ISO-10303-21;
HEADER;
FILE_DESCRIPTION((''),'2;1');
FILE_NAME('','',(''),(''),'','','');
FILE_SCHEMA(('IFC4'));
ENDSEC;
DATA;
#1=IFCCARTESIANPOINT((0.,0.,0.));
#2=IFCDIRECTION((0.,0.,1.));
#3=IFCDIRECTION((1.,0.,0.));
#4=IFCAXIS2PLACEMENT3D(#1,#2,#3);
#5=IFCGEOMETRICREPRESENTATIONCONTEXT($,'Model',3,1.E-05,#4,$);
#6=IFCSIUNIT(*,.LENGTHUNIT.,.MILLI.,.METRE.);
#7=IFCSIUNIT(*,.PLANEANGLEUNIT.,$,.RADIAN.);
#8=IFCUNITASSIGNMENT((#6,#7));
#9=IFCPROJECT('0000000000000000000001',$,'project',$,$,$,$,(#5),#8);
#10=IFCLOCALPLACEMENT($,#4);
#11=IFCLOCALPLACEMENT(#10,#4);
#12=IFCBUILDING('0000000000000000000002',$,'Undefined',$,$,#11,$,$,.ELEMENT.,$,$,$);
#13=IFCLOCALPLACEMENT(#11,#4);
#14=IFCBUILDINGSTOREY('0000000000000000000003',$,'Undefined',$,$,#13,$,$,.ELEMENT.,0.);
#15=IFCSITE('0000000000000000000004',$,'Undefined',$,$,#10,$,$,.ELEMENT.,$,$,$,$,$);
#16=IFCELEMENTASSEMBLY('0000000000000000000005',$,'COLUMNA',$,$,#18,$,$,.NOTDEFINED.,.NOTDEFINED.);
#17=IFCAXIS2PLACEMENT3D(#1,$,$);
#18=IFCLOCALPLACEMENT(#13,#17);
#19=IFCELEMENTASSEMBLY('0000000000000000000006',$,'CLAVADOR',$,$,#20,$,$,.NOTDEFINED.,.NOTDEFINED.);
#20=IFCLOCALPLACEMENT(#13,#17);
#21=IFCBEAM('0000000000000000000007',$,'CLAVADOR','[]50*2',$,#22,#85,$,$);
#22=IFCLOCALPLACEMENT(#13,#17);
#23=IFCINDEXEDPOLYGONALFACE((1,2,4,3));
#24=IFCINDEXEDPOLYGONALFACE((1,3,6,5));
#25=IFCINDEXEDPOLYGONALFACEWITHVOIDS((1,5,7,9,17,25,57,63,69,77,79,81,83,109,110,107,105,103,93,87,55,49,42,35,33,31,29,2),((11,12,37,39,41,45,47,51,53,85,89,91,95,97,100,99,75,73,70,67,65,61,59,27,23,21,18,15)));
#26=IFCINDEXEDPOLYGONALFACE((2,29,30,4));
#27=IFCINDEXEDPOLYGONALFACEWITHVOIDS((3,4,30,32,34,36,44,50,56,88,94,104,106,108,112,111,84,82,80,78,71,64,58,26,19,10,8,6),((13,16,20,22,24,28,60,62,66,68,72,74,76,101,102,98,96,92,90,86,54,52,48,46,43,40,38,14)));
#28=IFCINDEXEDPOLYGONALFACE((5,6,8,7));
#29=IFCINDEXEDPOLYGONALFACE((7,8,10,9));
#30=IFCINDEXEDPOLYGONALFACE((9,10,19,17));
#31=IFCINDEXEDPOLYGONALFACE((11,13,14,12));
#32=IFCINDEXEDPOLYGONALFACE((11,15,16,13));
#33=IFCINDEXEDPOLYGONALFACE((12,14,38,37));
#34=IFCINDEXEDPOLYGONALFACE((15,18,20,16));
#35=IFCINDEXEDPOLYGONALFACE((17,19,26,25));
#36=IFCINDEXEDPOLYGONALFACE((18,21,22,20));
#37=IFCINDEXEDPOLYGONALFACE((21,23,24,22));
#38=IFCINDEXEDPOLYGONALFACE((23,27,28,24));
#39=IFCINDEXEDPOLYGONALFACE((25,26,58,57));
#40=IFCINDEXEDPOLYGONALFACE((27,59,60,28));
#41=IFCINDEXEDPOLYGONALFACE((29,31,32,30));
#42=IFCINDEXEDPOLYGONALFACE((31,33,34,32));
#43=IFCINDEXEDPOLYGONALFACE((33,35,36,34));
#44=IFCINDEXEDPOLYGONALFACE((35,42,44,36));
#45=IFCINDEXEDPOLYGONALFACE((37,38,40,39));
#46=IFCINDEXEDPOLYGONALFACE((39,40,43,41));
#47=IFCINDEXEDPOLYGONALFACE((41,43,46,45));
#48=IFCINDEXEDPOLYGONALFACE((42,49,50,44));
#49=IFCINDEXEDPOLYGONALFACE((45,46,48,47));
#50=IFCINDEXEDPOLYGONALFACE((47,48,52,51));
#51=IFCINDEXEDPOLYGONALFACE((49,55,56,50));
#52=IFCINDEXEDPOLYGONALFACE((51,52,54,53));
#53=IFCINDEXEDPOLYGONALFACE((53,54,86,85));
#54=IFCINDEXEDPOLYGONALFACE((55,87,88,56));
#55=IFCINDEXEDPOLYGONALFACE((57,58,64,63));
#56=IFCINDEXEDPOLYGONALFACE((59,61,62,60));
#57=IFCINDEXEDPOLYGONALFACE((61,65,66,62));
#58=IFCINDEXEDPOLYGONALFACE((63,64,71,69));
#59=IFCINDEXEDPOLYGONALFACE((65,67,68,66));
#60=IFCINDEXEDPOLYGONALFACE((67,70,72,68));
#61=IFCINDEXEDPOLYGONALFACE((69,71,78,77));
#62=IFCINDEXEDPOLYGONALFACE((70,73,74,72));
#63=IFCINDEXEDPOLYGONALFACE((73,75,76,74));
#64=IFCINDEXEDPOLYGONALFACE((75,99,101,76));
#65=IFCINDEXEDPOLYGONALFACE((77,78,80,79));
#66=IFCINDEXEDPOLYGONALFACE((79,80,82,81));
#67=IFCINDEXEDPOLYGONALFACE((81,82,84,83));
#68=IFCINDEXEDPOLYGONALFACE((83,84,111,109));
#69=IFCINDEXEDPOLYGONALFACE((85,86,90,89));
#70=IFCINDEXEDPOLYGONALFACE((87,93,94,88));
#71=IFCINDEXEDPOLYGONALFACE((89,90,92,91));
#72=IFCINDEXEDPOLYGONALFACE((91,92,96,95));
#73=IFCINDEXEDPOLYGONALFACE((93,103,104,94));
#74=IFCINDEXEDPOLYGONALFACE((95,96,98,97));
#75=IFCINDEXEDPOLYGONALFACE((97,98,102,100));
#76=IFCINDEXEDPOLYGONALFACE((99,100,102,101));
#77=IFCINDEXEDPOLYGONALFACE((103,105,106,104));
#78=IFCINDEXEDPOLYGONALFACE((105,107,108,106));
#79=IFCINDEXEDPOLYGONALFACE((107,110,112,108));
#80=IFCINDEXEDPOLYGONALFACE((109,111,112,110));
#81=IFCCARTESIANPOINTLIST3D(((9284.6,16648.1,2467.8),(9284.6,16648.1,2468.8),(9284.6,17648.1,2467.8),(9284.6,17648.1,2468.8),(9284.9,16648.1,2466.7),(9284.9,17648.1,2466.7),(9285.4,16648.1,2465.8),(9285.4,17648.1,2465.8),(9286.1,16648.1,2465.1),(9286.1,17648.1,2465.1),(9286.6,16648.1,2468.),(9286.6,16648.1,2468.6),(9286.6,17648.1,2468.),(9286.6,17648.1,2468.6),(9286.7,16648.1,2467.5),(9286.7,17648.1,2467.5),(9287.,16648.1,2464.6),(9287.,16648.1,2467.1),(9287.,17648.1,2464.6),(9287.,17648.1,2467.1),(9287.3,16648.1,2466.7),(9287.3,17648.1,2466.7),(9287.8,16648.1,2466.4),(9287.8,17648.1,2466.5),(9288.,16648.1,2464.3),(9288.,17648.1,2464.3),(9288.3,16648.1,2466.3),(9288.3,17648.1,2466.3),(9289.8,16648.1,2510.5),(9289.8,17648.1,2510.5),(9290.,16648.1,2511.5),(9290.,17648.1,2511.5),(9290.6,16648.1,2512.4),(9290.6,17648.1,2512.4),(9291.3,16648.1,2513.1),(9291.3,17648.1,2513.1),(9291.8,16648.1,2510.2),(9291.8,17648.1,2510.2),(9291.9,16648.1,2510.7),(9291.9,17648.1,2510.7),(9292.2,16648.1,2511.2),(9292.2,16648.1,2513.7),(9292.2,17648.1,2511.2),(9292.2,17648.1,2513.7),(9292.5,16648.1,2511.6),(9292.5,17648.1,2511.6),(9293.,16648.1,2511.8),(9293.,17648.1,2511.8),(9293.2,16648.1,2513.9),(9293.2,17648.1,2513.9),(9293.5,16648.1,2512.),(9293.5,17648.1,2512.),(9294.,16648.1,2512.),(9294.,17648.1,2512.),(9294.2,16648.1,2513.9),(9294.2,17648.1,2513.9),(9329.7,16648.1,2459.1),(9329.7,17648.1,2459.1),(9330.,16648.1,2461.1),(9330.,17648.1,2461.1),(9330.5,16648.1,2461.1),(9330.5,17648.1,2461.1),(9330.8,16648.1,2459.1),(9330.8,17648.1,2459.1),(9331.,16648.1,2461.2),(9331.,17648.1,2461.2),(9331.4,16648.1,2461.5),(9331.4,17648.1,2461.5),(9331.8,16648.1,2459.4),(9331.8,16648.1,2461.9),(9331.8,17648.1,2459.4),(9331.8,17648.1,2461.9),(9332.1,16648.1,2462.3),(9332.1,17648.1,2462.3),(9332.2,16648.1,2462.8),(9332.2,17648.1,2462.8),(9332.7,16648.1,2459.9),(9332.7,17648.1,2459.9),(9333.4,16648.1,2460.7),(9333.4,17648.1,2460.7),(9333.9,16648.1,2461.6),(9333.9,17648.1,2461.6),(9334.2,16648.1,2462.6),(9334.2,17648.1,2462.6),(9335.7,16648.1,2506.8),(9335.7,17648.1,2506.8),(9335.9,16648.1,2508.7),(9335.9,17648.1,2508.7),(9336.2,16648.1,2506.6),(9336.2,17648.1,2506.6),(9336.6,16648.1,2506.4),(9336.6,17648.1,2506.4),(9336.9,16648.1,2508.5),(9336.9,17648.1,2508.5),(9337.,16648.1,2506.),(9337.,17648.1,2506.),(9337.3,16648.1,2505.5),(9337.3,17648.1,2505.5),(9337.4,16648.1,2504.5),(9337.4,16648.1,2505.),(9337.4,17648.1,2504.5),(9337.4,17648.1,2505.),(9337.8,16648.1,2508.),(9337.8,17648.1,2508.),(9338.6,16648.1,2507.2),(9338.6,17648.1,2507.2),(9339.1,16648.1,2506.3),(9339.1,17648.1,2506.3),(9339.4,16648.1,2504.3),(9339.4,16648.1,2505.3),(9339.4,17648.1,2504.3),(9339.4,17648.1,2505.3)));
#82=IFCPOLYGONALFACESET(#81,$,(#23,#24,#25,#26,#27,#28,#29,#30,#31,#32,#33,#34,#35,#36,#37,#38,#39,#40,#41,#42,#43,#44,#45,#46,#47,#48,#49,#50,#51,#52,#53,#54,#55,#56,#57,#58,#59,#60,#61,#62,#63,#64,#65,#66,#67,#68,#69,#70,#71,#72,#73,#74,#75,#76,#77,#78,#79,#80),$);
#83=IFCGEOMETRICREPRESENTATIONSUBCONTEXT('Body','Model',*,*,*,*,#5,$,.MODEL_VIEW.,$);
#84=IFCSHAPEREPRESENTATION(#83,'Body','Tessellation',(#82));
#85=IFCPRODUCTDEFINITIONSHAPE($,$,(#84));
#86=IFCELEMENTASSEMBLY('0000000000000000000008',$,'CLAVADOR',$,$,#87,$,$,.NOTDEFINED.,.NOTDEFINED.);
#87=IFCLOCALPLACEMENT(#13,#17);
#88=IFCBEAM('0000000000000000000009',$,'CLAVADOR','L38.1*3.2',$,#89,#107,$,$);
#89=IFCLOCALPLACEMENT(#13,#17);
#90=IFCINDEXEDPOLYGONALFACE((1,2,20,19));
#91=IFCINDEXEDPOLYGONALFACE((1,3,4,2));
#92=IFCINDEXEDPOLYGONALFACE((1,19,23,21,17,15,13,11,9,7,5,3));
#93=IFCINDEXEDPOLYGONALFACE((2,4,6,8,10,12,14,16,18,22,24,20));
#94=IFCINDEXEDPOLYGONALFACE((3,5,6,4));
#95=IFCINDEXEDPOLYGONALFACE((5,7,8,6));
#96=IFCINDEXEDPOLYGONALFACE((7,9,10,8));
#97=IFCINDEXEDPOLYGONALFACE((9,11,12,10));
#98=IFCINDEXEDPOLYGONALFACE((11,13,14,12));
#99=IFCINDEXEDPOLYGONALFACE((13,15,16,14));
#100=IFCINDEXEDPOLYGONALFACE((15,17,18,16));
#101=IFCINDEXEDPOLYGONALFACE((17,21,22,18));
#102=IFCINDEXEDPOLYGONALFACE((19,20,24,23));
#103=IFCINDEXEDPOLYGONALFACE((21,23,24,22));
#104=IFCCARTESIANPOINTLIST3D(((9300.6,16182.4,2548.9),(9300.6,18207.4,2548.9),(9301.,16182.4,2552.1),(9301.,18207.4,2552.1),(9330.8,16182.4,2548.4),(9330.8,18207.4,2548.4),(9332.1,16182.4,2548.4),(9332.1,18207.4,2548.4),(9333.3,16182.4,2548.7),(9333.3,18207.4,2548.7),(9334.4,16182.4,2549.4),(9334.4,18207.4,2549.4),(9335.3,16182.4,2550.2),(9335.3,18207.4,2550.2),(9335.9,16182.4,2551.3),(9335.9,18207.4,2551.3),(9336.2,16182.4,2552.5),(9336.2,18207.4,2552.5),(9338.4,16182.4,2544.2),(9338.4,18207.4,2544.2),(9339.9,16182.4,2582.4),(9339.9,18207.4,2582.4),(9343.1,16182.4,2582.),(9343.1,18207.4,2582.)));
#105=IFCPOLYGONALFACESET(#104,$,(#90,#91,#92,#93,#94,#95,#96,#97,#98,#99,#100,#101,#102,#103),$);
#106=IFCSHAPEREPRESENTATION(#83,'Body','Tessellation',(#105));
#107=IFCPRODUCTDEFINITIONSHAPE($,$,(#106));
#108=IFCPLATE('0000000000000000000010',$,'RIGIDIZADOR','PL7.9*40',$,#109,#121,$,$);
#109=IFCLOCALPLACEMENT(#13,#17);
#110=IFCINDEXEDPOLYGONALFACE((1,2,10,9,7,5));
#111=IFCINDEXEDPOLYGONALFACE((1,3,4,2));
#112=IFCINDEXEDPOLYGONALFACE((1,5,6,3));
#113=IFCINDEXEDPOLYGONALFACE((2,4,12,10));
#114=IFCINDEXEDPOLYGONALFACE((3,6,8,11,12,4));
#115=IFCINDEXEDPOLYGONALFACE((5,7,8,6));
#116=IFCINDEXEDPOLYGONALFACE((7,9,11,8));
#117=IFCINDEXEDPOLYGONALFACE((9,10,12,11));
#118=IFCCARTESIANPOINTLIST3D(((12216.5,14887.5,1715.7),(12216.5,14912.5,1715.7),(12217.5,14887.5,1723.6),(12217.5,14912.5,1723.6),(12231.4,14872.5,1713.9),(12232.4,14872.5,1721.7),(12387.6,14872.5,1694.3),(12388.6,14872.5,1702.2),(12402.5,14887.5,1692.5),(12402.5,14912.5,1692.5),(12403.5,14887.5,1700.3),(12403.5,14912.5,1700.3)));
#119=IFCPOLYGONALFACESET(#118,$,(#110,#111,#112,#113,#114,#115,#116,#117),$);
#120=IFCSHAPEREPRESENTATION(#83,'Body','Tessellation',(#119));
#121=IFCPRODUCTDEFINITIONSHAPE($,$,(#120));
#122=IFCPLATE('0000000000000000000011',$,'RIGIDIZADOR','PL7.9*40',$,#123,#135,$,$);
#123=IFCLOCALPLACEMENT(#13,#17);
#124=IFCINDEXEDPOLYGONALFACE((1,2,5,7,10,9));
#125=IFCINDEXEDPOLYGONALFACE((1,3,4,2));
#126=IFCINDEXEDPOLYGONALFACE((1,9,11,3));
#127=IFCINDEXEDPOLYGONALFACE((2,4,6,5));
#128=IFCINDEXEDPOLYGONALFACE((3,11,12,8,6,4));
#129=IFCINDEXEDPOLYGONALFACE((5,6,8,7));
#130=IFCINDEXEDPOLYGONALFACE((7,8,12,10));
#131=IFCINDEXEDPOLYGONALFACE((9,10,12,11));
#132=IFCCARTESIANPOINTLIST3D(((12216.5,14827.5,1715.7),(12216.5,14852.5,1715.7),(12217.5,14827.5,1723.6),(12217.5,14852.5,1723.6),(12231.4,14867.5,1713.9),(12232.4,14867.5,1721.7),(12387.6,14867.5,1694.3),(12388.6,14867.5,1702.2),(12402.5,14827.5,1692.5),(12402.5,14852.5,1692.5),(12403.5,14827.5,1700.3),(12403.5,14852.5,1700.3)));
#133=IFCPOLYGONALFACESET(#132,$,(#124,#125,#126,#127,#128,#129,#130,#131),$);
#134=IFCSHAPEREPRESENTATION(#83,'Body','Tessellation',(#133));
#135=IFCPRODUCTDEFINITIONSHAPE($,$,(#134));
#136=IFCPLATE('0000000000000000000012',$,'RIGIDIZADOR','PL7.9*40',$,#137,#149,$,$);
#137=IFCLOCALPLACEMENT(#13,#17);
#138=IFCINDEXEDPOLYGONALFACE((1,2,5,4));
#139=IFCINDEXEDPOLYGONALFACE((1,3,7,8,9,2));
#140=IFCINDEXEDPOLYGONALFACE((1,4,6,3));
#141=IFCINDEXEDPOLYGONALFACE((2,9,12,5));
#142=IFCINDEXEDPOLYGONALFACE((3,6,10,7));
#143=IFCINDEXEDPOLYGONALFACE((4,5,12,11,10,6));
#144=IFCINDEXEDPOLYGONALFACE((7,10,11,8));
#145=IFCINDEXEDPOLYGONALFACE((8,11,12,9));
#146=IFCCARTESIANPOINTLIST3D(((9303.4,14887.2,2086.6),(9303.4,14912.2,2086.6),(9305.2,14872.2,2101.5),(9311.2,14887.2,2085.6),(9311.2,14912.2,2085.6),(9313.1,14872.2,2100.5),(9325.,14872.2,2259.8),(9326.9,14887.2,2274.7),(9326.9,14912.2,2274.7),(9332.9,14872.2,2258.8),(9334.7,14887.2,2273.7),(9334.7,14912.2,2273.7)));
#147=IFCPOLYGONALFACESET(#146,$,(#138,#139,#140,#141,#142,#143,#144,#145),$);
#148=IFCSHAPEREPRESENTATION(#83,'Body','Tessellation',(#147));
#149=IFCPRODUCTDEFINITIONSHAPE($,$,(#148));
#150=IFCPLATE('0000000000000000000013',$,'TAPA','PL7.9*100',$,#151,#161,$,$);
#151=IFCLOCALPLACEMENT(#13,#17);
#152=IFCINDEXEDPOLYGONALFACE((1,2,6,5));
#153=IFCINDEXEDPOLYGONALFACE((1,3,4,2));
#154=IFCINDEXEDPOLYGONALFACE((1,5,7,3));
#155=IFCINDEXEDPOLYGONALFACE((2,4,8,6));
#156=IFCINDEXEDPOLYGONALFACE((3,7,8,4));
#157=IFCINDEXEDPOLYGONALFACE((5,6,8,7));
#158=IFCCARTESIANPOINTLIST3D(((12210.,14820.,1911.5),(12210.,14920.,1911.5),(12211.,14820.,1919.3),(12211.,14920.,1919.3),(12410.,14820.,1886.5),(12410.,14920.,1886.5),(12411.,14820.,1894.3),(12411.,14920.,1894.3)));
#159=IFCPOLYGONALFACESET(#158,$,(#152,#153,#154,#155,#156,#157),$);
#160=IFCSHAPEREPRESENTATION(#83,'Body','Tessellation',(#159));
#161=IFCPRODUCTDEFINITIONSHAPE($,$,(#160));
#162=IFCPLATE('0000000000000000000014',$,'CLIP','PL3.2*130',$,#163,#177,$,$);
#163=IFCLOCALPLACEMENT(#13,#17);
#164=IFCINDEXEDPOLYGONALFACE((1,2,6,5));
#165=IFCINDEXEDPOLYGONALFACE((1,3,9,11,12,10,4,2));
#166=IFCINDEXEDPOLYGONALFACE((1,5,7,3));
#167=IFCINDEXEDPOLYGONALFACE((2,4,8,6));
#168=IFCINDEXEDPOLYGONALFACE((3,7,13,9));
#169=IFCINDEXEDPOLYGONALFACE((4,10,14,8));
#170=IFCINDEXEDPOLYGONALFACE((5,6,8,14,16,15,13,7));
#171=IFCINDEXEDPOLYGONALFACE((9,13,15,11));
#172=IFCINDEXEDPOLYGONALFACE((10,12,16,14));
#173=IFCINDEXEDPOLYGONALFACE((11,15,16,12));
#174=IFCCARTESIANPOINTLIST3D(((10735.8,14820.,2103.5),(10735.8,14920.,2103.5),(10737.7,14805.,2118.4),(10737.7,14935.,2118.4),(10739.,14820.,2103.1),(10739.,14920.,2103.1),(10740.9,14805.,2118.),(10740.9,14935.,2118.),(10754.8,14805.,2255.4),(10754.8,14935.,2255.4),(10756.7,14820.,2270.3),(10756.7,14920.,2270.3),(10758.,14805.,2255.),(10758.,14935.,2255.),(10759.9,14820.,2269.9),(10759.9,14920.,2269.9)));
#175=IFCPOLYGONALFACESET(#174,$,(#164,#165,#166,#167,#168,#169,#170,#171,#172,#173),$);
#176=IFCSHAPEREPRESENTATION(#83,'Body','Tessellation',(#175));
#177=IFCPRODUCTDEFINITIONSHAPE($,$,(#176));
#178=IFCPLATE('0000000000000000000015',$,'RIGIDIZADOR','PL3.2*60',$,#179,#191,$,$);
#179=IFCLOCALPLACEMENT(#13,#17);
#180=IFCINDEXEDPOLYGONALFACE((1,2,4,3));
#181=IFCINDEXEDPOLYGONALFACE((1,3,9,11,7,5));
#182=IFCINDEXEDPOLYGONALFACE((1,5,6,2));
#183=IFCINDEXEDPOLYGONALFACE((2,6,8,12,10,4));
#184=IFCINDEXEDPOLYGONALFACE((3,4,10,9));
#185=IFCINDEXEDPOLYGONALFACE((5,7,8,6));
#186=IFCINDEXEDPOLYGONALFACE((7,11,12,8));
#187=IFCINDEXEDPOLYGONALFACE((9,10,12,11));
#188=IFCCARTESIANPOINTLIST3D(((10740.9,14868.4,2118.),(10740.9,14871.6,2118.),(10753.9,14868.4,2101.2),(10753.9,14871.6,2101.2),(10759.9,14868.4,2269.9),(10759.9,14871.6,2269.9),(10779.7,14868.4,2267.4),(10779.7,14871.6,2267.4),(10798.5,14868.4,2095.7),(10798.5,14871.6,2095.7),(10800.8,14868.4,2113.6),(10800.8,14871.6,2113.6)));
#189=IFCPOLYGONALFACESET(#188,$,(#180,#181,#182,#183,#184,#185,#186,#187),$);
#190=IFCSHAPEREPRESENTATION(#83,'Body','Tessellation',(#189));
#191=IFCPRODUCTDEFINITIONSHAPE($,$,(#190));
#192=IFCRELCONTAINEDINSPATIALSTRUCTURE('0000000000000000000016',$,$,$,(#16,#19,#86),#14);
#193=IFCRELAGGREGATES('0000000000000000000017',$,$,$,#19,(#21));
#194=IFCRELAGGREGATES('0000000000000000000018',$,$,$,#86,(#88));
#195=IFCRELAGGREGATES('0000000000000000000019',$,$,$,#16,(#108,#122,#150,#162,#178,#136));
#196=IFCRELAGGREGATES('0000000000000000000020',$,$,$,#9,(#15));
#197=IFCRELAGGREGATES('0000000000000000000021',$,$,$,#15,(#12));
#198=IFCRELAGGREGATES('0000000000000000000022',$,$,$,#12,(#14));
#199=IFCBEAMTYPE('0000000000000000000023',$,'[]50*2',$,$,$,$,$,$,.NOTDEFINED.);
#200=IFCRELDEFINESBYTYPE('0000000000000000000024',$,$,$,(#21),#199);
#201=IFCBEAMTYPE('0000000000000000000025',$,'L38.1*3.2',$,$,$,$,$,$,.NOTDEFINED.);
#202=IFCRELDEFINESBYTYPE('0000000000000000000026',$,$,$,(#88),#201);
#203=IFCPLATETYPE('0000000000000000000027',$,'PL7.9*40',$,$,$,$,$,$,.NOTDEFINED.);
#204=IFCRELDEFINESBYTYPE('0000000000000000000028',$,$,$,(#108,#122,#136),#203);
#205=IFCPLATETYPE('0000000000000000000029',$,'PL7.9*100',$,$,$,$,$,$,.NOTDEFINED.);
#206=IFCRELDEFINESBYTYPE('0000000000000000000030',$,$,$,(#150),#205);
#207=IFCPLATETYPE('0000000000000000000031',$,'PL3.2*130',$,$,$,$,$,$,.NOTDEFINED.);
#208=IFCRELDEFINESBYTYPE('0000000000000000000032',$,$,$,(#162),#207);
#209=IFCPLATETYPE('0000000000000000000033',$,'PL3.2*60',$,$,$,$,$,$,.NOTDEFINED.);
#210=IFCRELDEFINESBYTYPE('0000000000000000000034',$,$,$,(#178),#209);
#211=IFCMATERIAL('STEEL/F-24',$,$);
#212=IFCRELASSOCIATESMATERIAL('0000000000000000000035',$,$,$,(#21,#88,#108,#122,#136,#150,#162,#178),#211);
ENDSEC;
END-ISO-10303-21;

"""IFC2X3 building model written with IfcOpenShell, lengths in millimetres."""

from ifc_helpers import new_model, si_unit, frame, origin_with_axes, origin_2d_with_axis, place, context, subcontext, project, spatial, polyline, hollow_rectangle, l_section, outline, extrude, material, type_object, element, aggregate, save


model = new_model("IFC2X3")

# Units and contexts
model_context = context("Model", 3, precision=1e-05, world=origin_with_axes())
body_context = subcontext(model_context, "Body", "Model", "MODEL_VIEW")
ifc_project = project(units=[si_unit("LENGTHUNIT", "METRE", prefix="MILLI"), si_unit("PLANEANGLEUNIT", "RADIAN")], contexts=[model_context])

# Site, building, storey
site_placement = place(None, origin_with_axes())
site = spatial("IfcSite", under=ifc_project, at=site_placement, Name="Undefined", CompositionType="ELEMENT")
building_placement = place(site_placement, origin_with_axes())
building = spatial("IfcBuilding", under=site, at=building_placement, Name="Undefined", CompositionType="ELEMENT")
storey_placement = place(building_placement, origin_with_axes())
storey = spatial("IfcBuildingStorey", under=building, at=storey_placement, Name="Undefined", CompositionType="ELEMENT", Elevation=0.0)

# Element assembly
assembly_1_placement = place(storey_placement, origin_with_axes())
assembly_1 = element("IfcElementAssembly", 1, at=assembly_1_placement, inside=storey, Name="COLUMNA", AssemblyPlace="NOTDEFINED", PredefinedType="NOTDEFINED")
ifc_material_1 = material(Name="STEEL/F-24")

# Element assemblies, beams
assembly_2_placement = place(storey_placement, origin_with_axes())
assembly_2 = element("IfcElementAssembly", 2, at=assembly_2_placement, inside=storey, Name="CLAVADOR", AssemblyPlace="NOTDEFINED", PredefinedType="NOTDEFINED")
beam_type_1 = type_object("IfcBeamType", Name="[]50*2", PredefinedType="NOTDEFINED")
beam_1_placement = place(assembly_2_placement, frame((9312.0, 16648.1, 2486.5), z_axis=(0.992273, 0.0, -0.124075), x_axis=(0.0, 1.0, 0.000001)))
beam_1 = element("IfcBeam", 3, at=beam_1_placement, type_object=beam_type_1, material=ifc_material_1, Name="CLAVADOR", Description="[]50*2", context=body_context, shape_type="SweptSolid", body=[
    extrude(hollow_rectangle(XDim=50.0, YDim=50.0, WallThickness=2.0, InnerFilletRadius=2.0, OuterFilletRadius=4.0, at=origin_2d_with_axis()), frame((1000.0, 0.0, 0.0), z_axis=(-1.0, 0.0, 0.0), x_axis=(0.0, -1.0, 0.0)), (0.0, 0.0, 1.0), 1000.0),
])
aggregate(assembly_2, [beam_1])
assembly_3_placement = place(storey_placement, origin_with_axes())
assembly_3 = element("IfcElementAssembly", 4, at=assembly_3_placement, inside=storey, Name="CLAVADOR", AssemblyPlace="NOTDEFINED", PredefinedType="NOTDEFINED")
beam_type_2 = type_object("IfcBeamType", Name="L38.1*3.2", PredefinedType="NOTDEFINED")
beam_2_placement = place(assembly_3_placement, frame((9321.8, 16182.4, 2565.5), z_axis=(-0.992273, 0.0, 0.124075), x_axis=(0.0, 1.0, 0.0)))
beam_2 = element("IfcBeam", 5, at=beam_2_placement, type_object=beam_type_2, material=ifc_material_1, Name="CLAVADOR", Description="L38.1*3.2", context=body_context, shape_type="SweptSolid", body=[
    extrude(l_section(Depth=38.1, Width=38.1, Thickness=3.2, FilletRadius=4.8, at=origin_2d_with_axis()), frame((2025.0, 0.0, 0.0), z_axis=(-1.0, 0.0, 0.0), x_axis=(0.0, -1.0, 0.0)), (0.0, 0.0, 1.0), 2025.0),
])
aggregate(assembly_3, [beam_2])

# Plates
plate_type_1 = type_object("IfcPlateType", Name="PL7.9*40", PredefinedType="NOTDEFINED")
plate_1_placement = place(assembly_1_placement, frame((12217.0, 14912.5, 1719.6), z_axis=(0.124075, 0.0, 0.992273), x_axis=(0.0, -1.0, 0.0)))
plate_1 = element("IfcPlate", 6, at=plate_1_placement, type_object=plate_type_1, material=ifc_material_1, Name="RIGIDIZADOR", Description="PL7.9*40", context=body_context, shape_type="SweptSolid", body=[
    extrude(outline(polyline([(0.0, 0.0), (25.0, 0.0), (40.0, 15.0), (40.0, 172.5), (25.0, 187.5), (0.0, 187.5), (0.0, 0.0)])), frame((0.0, 0.0, -4.0), z_axis=(0.0, 0.0, 1.0), x_axis=(1.0, 0.0, 0.0)), (0.0, 0.0, 1.0), 7.9),
])
plate_2_placement = place(assembly_1_placement, frame((12217.0, 14867.5, 1719.6), z_axis=(0.124075, 0.0, 0.992273), x_axis=(0.0, -1.0, 0.0)))
plate_2 = element("IfcPlate", 7, at=plate_2_placement, type_object=plate_type_1, material=ifc_material_1, Name="RIGIDIZADOR", Description="PL7.9*40", context=body_context, shape_type="SweptSolid", body=[
    extrude(outline(polyline([(0.0, 15.0), (15.0, 0.0), (40.0, 0.0), (40.0, 187.5), (15.0, 187.5), (0.0, 172.5), (0.0, 15.0)])), frame((0.0, 0.0, -4.0), z_axis=(0.0, 0.0, 1.0), x_axis=(1.0, 0.0, 0.0)), (0.0, 0.0, 1.0), 7.9),
])
plate_3_placement = place(assembly_1_placement, frame((9307.3, 14912.2, 2086.1), z_axis=(-0.992273, 0.0, 0.124075), x_axis=(0.0, -1.0, 0.0)))
plate_3 = element("IfcPlate", 8, at=plate_3_placement, type_object=plate_type_1, material=ifc_material_1, Name="RIGIDIZADOR", Description="PL7.9*40", context=body_context, shape_type="SweptSolid", body=[
    extrude(outline(polyline([(0.0, 0.0), (25.0, 0.0), (40.0, 15.0), (40.0, 174.6), (25.0, 189.6), (0.0, 189.6), (0.0, 0.0)])), frame((0.0, 0.0, -4.0), z_axis=(0.0, 0.0, 1.0), x_axis=(1.0, 0.0, 0.0)), (0.0, 0.0, 1.0), 7.9),
])
plate_type_2 = type_object("IfcPlateType", Name="PL7.9*100", PredefinedType="NOTDEFINED")
plate_4_placement = place(assembly_1_placement, frame((12210.5, 14870.0, 1915.4), z_axis=(-0.124075, 0.0, -0.992273), x_axis=(0.992273, 0.0, -0.124075)))
plate_4 = element("IfcPlate", 9, at=plate_4_placement, type_object=plate_type_2, material=ifc_material_1, Name="TAPA", Description="PL7.9*100", context=body_context, shape_type="SweptSolid", body=[
    extrude(outline(polyline([(0.0, -50.0), (0.0, 50.0), (201.6, 50.0), (201.6, -50.0), (0.0, -50.0)])), frame((0.0, 0.0, -4.0), z_axis=(0.0, 0.0, 1.0), x_axis=(1.0, 0.0, 0.0)), (0.0, 0.0, 1.0), 7.9),
])
plate_type_3 = type_object("IfcPlateType", Name="PL3.2*130", PredefinedType="NOTDEFINED")
plate_5_placement = place(assembly_1_placement, frame((10758.3, 14805.0, 2270.1), z_axis=(-0.992275, 0.0, 0.124059), x_axis=(0.0, 1.0, 0.0)))
plate_5 = element("IfcPlate", 10, at=plate_5_placement, type_object=plate_type_3, material=ifc_material_1, Name="CLIP", Description="PL3.2*130", context=body_context, shape_type="SweptSolid", body=[
    extrude(outline(polyline([(0.0, 15.0), (15.0, 0.0), (115.0, 0.0), (130.0, 15.0), (130.0, 153.1), (115.0, 168.1), (15.0, 168.1), (0.0, 153.1), (0.0, 15.0)])), frame((0.0, 0.0, -1.6), z_axis=(0.0, 0.0, 1.0), x_axis=(1.0, 0.0, 0.0)), (0.0, 0.0, 1.0), 3.2),
])
plate_type_4 = type_object("IfcPlateType", Name="PL3.2*60", PredefinedType="NOTDEFINED")
plate_6_placement = place(assembly_1_placement, frame((10759.9, 14870.0, 2269.9), z_axis=(0.0, 1.0, 0.0), x_axis=(0.992289, 0.0, -0.123943)))
plate_6 = element("IfcPlate", 11, at=plate_6_placement, type_object=plate_type_4, material=ifc_material_1, Name="RIGIDIZADOR", Description="PL3.2*60", context=body_context, shape_type="SweptSolid", body=[
    extrude(outline(polyline([(0.0, 0.0), (20.0, 0.0), (60.0, 150.0), (60.0, 168.1), (15.0, 168.1), (0.0, 153.1), (0.0, 0.0)])), frame((0.0, 0.0, -1.6), z_axis=(0.0, 0.0, 1.0), x_axis=(1.0, 0.0, 0.0)), (0.0, 0.0, 1.0), 3.2),
])

aggregate(assembly_1, [plate_1, plate_2, plate_4, plate_5, plate_6, plate_3])

save(model, "model.ifc")
